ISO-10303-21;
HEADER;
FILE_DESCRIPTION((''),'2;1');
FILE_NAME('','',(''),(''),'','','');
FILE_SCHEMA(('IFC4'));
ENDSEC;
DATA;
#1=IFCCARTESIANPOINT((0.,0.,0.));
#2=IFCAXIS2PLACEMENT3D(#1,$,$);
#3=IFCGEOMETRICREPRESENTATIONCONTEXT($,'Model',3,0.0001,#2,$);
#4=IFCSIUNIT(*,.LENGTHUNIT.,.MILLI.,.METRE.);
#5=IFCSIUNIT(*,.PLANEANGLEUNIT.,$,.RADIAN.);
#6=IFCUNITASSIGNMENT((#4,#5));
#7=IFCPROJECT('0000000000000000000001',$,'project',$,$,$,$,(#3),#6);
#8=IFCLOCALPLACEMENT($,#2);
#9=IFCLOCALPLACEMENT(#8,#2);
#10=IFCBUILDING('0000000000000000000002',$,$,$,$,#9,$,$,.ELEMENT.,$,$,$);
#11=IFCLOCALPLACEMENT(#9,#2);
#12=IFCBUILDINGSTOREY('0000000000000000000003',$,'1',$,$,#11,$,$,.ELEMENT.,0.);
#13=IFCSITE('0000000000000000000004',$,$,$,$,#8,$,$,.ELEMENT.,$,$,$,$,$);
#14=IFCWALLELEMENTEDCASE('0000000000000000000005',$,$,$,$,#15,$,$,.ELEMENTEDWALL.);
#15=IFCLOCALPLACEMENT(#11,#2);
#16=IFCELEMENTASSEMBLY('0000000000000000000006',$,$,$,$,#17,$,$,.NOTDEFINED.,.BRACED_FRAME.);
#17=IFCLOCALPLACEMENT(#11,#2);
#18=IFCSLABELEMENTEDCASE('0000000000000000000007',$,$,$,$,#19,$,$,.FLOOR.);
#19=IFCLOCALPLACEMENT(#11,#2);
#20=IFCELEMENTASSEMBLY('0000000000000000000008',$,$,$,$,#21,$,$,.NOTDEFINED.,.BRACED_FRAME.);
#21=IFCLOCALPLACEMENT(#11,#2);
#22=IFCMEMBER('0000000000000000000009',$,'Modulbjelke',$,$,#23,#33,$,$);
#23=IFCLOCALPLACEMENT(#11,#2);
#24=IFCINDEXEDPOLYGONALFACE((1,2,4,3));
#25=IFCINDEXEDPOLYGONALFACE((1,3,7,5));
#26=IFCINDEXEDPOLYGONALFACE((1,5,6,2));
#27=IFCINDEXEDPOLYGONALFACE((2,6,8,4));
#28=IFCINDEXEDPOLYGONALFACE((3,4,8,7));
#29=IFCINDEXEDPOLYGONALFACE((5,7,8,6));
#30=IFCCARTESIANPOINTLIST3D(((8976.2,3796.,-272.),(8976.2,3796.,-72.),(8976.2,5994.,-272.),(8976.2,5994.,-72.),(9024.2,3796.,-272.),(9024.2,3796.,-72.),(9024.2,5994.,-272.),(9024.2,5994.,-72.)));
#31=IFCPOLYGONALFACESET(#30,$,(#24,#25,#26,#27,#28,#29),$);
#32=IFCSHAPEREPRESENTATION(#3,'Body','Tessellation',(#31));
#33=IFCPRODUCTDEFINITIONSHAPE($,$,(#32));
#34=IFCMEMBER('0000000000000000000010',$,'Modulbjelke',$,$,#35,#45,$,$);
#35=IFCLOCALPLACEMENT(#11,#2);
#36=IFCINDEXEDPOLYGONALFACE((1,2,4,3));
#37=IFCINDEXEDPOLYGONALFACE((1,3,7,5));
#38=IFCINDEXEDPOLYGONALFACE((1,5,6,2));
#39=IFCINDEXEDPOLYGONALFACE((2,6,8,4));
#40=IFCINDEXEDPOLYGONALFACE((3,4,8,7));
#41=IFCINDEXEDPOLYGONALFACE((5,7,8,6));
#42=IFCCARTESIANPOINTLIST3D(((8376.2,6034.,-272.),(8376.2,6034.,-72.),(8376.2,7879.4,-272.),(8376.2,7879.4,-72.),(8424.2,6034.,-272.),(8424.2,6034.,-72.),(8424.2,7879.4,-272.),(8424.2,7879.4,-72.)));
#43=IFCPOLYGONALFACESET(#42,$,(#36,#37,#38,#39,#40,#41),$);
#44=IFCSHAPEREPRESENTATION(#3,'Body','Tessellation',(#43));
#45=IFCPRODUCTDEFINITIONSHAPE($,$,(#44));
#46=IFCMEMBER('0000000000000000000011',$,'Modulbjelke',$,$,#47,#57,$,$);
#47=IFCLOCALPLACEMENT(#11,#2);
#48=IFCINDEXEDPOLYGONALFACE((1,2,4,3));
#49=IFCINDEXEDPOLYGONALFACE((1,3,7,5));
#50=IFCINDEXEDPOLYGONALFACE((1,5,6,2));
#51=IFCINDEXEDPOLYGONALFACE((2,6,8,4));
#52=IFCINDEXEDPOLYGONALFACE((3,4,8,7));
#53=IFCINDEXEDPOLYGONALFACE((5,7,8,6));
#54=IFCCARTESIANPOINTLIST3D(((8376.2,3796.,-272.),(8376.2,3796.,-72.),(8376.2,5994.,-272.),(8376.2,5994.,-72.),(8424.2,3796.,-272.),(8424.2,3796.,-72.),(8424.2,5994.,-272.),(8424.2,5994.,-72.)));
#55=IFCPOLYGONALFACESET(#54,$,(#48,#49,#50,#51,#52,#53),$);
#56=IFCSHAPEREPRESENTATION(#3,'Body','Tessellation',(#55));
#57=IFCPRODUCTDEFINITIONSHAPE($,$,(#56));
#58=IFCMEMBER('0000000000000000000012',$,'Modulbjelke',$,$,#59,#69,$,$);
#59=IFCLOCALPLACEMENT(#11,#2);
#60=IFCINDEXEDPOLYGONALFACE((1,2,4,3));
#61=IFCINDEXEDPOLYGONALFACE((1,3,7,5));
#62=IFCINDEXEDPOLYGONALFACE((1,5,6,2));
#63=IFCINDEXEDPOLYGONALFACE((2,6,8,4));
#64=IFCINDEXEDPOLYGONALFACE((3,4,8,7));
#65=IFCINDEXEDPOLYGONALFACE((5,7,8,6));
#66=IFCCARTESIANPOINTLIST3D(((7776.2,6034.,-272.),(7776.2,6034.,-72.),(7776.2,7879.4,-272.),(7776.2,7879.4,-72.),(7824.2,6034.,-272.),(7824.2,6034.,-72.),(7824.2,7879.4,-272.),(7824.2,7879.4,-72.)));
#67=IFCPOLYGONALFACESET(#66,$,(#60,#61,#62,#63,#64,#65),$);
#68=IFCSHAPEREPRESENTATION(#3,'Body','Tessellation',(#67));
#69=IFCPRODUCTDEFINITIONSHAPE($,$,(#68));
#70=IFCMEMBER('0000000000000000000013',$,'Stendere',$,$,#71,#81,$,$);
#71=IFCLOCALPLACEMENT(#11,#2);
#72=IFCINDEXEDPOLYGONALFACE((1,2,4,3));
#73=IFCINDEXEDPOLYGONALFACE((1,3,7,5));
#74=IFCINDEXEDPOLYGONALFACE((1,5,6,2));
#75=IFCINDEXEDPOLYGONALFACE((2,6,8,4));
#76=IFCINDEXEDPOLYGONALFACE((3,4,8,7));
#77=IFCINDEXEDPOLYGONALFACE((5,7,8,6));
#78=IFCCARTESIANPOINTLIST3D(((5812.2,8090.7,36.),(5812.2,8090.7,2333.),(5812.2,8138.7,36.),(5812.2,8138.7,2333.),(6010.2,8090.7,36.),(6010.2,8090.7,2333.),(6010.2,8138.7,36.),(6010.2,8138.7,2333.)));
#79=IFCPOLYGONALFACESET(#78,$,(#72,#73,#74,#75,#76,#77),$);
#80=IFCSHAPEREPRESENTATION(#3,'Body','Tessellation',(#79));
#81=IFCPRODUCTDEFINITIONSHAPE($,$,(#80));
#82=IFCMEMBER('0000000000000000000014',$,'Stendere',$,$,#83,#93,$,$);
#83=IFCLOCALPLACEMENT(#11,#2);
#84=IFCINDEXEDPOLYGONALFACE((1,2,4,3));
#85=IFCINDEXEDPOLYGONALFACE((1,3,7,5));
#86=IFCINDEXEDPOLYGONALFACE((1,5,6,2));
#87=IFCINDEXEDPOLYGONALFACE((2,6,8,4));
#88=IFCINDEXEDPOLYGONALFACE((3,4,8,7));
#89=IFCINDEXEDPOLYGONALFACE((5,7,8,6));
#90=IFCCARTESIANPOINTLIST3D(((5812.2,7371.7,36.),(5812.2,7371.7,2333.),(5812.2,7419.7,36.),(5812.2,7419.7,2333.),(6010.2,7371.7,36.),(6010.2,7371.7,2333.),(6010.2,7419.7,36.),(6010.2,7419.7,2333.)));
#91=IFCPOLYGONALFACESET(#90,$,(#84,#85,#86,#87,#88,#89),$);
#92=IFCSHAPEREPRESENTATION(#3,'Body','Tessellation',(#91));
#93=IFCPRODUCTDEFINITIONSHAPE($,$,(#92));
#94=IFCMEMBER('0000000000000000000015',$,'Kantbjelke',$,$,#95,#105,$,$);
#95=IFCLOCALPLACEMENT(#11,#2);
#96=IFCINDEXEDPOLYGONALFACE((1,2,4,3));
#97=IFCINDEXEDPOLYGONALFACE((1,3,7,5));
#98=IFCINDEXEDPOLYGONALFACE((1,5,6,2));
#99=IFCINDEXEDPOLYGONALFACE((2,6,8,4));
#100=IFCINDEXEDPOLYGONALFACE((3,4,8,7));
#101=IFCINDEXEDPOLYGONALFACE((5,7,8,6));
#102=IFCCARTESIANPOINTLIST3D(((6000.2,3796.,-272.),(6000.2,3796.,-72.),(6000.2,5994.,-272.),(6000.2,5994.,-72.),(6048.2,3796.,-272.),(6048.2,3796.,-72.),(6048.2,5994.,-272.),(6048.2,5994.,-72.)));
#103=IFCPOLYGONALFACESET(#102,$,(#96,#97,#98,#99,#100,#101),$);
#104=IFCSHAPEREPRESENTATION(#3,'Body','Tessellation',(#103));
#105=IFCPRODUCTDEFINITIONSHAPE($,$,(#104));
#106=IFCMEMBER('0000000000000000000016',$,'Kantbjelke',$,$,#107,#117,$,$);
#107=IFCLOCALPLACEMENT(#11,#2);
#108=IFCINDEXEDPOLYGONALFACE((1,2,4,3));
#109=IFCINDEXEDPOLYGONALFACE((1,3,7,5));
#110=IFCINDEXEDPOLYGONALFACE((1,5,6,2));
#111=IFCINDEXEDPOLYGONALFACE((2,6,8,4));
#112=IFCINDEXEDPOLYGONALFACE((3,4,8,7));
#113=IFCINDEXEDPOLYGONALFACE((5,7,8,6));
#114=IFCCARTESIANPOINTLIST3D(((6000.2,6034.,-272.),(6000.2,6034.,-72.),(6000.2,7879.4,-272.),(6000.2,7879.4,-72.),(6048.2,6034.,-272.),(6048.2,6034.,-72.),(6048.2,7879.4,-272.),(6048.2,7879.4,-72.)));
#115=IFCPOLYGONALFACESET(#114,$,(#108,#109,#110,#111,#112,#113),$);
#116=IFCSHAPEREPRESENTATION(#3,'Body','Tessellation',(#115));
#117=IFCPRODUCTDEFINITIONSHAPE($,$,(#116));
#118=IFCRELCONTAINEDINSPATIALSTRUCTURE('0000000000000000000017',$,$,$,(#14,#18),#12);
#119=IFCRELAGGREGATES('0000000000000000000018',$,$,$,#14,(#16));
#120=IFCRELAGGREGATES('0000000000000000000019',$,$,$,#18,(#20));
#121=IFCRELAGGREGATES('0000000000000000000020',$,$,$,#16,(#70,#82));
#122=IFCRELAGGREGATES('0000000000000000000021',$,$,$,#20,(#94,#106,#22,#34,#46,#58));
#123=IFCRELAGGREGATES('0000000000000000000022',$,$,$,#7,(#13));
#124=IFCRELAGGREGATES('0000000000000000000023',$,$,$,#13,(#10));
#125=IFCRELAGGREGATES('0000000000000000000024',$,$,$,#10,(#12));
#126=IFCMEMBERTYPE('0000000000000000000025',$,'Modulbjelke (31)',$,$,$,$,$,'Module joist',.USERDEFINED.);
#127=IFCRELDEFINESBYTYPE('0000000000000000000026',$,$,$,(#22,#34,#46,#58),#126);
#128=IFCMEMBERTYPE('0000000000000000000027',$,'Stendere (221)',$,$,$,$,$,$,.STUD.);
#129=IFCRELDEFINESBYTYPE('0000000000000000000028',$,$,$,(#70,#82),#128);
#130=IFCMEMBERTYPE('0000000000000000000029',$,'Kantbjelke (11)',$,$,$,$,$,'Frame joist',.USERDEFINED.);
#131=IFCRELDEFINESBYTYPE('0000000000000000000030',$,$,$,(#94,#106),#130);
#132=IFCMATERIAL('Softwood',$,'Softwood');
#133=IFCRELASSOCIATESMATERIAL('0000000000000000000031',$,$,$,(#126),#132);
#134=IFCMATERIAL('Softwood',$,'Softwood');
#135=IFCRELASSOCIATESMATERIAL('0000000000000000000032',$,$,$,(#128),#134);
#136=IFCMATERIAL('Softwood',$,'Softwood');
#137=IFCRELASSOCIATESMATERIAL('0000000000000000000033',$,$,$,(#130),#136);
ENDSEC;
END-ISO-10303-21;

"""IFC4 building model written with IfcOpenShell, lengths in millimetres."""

from ifc_helpers import new_model, si_unit, frame, origin, place, context, project, spatial, rectangle, extrude, clip, halfspace, material, material_profile, profile_set, type_object, element, aggregate, save


model = new_model("IFC4")

# Units and contexts
model_context = context("Model", 3, precision=0.0001, world=origin())
ifc_project = project(units=[si_unit("LENGTHUNIT", "METRE", prefix="MILLI"), si_unit("PLANEANGLEUNIT", "RADIAN")], contexts=[model_context])

# Site, building, storey
site_placement = place(None, origin())
site = spatial("IfcSite", under=ifc_project, at=site_placement, CompositionType="ELEMENT")
building_placement = place(site_placement, origin())
building = spatial("IfcBuilding", under=site, at=building_placement, CompositionType="ELEMENT")
storey_placement = place(building_placement, origin())
storey = spatial("IfcBuildingStorey", under=building, at=storey_placement, Name="1", CompositionType="ELEMENT", Elevation=0.0)

# Wall, element assembly
wall_1_placement = place(storey_placement, frame((6010.2, 8138.7, 0.0), z_axis=(-1.0, 0.0, 0.0), x_axis=(0.0, -1.0, 0.0)))
wall_1 = element("IfcWallElementedCase", 1, at=wall_1_placement, inside=storey, PredefinedType="ELEMENTEDWALL")
assembly_1_placement = place(wall_1_placement, origin())
assembly_1 = element("IfcElementAssembly", 2, at=assembly_1_placement, AssemblyPlace="NOTDEFINED", PredefinedType="BRACED_FRAME")
aggregate(wall_1, [assembly_1])

# Slab, element assembly, members
slab_placement = place(storey_placement, origin())
slab = element("IfcSlabElementedCase", 3, at=slab_placement, inside=storey, PredefinedType="FLOOR")
assembly_2_placement = place(slab_placement, frame((0.0, 0.0, -225.0)))
assembly_2 = element("IfcElementAssembly", 4, at=assembly_2_placement, AssemblyPlace="NOTDEFINED", PredefinedType="BRACED_FRAME")
aggregate(slab, [assembly_2])
ifc_material_1 = material(Name="Softwood", Category="Softwood")
ifc_material_profile_1 = material_profile(ifc_material_1, rectangle(XDim=48.0, YDim=200.0), Name="Modulbjelke (31)")
ifc_profile_set_1 = profile_set([ifc_material_profile_1])
member_type_1 = type_object("IfcMemberType", Name="Modulbjelke (31)", ElementType="Module joist", PredefinedType="USERDEFINED", material=ifc_profile_set_1)
member_1_placement = place(assembly_2_placement, frame((9000.2, 3796.0, -47.0), z_axis=(-0.000002, 1.0, 0.0), x_axis=(-1.0, -0.000002, 0.0)))
member_1 = element("IfcMember", 5, at=member_1_placement, type_object=member_type_1, Name="Modulbjelke", context=model_context, shape_type="Clipping", body=[
    clip(clip(extrude(rectangle(XDim=48.0, YDim=200.0), frame((0.0, 100.0, 0.0)), (0.0, 0.0, 1.0), 2198.0), halfspace(frame((0.0, 100.0, 0.0)), True)), halfspace(frame((0.0, 100.0, 2198.0)), False)),
])
member_2_placement = place(assembly_2_placement, frame((8400.2, 6034.0, -47.0), z_axis=(0.000002, 1.0, 0.0), x_axis=(-1.0, 0.000002, 0.0)))
member_2 = element("IfcMember", 6, at=member_2_placement, type_object=member_type_1, Name="Modulbjelke", context=model_context, shape_type="Clipping", body=[
    clip(clip(extrude(rectangle(XDim=48.0, YDim=200.0), frame((0.0, 100.0, 0.0)), (0.0, 0.0, 1.0), 1845.4), halfspace(frame((0.0, 100.0, 0.0)), True)), halfspace(frame((0.0, 100.0, 1845.4)), False)),
])
member_3_placement = place(assembly_2_placement, frame((8400.2, 3796.0, -47.0), z_axis=(-0.000002, 1.0, 0.0), x_axis=(-1.0, -0.000002, 0.0)))
member_3 = element("IfcMember", 7, at=member_3_placement, type_object=member_type_1, Name="Modulbjelke", context=model_context, shape_type="Clipping", body=[
    clip(clip(extrude(rectangle(XDim=48.0, YDim=200.0), frame((0.0, 100.0, 0.0)), (0.0, 0.0, 1.0), 2198.0), halfspace(frame((0.0, 100.0, 0.0)), True)), halfspace(frame((0.0, 100.0, 2198.0)), False)),
])
member_4_placement = place(assembly_2_placement, frame((7800.2, 6034.0, -47.0), z_axis=(-0.000003, 1.0, 0.0), x_axis=(-1.0, -0.000003, 0.0)))
member_4 = element("IfcMember", 8, at=member_4_placement, type_object=member_type_1, Name="Modulbjelke", context=model_context, shape_type="Clipping", body=[
    clip(clip(extrude(rectangle(XDim=48.0, YDim=200.0), frame((0.0, 100.0, 0.0)), (0.0, 0.0, 1.0), 1845.4), halfspace(frame((0.0, 100.0, 0.0)), True)), halfspace(frame((0.0, 100.0, 1845.4)), False)),
])

# Members
ifc_material_2 = material(Name="Softwood", Category="Softwood")
ifc_material_profile_2 = material_profile(ifc_material_2, rectangle(XDim=48.0, YDim=198.0), Name="Stendere (221)")
ifc_profile_set_2 = profile_set([ifc_material_profile_2])
member_type_2 = type_object("IfcMemberType", Name="Stendere (221)", PredefinedType="STUD", material=ifc_profile_set_2)
member_5_placement = place(assembly_1_placement, frame((24.0, 36.0, 0.0), z_axis=(0.0, 1.0, 0.0), x_axis=(-1.0, 0.0, 0.0)))
member_5 = element("IfcMember", 9, at=member_5_placement, type_object=member_type_2, Name="Stendere", context=model_context, shape_type="SweptSolid", body=[
    extrude(rectangle(XDim=48.0, YDim=198.0), frame((0.0, 99.0, 0.0)), (0.0, 0.0, 1.0), 2297.0),
])
member_6_placement = place(assembly_1_placement, frame((743.0, 36.0, 0.0), z_axis=(0.0, 1.0, 0.0), x_axis=(-1.0, 0.0, 0.0)))
member_6 = element("IfcMember", 10, at=member_6_placement, type_object=member_type_2, Name="Stendere", context=model_context, shape_type="SweptSolid", body=[
    extrude(rectangle(XDim=48.0, YDim=198.0), frame((0.0, 99.0, 0.0)), (0.0, 0.0, 1.0), 2297.0),
])
aggregate(assembly_1, [member_5, member_6])

# Members
ifc_material_3 = material(Name="Softwood", Category="Softwood")
ifc_material_profile_3 = material_profile(ifc_material_3, rectangle(XDim=48.0, YDim=200.0), Name="Kantbjelke (11)")
ifc_profile_set_3 = profile_set([ifc_material_profile_3])
member_type_3 = type_object("IfcMemberType", Name="Kantbjelke (11)", ElementType="Frame joist", PredefinedType="USERDEFINED", material=ifc_profile_set_3)
member_7_placement = place(assembly_2_placement, frame((6024.2, 5994.0, -47.0), z_axis=(0.0, -1.0, 0.0)))
member_7 = element("IfcMember", 11, at=member_7_placement, type_object=member_type_3, Name="Kantbjelke", context=model_context, shape_type="SweptSolid", body=[
    extrude(rectangle(XDim=48.0, YDim=200.0), frame((0.0, 100.0, 0.0)), (0.0, 0.0, 1.0), 2198.0),
])
member_8_placement = place(assembly_2_placement, frame((6024.2, 7879.4, -47.0), z_axis=(0.0, -1.0, 0.0)))
member_8 = element("IfcMember", 12, at=member_8_placement, type_object=member_type_3, Name="Kantbjelke", context=model_context, shape_type="SweptSolid", body=[
    extrude(rectangle(XDim=48.0, YDim=200.0), frame((0.0, 100.0, 0.0)), (0.0, 0.0, 1.0), 1845.4),
])
aggregate(assembly_2, [member_7, member_8, member_1, member_2, member_3, member_4])

save(model, "model.ifc")
